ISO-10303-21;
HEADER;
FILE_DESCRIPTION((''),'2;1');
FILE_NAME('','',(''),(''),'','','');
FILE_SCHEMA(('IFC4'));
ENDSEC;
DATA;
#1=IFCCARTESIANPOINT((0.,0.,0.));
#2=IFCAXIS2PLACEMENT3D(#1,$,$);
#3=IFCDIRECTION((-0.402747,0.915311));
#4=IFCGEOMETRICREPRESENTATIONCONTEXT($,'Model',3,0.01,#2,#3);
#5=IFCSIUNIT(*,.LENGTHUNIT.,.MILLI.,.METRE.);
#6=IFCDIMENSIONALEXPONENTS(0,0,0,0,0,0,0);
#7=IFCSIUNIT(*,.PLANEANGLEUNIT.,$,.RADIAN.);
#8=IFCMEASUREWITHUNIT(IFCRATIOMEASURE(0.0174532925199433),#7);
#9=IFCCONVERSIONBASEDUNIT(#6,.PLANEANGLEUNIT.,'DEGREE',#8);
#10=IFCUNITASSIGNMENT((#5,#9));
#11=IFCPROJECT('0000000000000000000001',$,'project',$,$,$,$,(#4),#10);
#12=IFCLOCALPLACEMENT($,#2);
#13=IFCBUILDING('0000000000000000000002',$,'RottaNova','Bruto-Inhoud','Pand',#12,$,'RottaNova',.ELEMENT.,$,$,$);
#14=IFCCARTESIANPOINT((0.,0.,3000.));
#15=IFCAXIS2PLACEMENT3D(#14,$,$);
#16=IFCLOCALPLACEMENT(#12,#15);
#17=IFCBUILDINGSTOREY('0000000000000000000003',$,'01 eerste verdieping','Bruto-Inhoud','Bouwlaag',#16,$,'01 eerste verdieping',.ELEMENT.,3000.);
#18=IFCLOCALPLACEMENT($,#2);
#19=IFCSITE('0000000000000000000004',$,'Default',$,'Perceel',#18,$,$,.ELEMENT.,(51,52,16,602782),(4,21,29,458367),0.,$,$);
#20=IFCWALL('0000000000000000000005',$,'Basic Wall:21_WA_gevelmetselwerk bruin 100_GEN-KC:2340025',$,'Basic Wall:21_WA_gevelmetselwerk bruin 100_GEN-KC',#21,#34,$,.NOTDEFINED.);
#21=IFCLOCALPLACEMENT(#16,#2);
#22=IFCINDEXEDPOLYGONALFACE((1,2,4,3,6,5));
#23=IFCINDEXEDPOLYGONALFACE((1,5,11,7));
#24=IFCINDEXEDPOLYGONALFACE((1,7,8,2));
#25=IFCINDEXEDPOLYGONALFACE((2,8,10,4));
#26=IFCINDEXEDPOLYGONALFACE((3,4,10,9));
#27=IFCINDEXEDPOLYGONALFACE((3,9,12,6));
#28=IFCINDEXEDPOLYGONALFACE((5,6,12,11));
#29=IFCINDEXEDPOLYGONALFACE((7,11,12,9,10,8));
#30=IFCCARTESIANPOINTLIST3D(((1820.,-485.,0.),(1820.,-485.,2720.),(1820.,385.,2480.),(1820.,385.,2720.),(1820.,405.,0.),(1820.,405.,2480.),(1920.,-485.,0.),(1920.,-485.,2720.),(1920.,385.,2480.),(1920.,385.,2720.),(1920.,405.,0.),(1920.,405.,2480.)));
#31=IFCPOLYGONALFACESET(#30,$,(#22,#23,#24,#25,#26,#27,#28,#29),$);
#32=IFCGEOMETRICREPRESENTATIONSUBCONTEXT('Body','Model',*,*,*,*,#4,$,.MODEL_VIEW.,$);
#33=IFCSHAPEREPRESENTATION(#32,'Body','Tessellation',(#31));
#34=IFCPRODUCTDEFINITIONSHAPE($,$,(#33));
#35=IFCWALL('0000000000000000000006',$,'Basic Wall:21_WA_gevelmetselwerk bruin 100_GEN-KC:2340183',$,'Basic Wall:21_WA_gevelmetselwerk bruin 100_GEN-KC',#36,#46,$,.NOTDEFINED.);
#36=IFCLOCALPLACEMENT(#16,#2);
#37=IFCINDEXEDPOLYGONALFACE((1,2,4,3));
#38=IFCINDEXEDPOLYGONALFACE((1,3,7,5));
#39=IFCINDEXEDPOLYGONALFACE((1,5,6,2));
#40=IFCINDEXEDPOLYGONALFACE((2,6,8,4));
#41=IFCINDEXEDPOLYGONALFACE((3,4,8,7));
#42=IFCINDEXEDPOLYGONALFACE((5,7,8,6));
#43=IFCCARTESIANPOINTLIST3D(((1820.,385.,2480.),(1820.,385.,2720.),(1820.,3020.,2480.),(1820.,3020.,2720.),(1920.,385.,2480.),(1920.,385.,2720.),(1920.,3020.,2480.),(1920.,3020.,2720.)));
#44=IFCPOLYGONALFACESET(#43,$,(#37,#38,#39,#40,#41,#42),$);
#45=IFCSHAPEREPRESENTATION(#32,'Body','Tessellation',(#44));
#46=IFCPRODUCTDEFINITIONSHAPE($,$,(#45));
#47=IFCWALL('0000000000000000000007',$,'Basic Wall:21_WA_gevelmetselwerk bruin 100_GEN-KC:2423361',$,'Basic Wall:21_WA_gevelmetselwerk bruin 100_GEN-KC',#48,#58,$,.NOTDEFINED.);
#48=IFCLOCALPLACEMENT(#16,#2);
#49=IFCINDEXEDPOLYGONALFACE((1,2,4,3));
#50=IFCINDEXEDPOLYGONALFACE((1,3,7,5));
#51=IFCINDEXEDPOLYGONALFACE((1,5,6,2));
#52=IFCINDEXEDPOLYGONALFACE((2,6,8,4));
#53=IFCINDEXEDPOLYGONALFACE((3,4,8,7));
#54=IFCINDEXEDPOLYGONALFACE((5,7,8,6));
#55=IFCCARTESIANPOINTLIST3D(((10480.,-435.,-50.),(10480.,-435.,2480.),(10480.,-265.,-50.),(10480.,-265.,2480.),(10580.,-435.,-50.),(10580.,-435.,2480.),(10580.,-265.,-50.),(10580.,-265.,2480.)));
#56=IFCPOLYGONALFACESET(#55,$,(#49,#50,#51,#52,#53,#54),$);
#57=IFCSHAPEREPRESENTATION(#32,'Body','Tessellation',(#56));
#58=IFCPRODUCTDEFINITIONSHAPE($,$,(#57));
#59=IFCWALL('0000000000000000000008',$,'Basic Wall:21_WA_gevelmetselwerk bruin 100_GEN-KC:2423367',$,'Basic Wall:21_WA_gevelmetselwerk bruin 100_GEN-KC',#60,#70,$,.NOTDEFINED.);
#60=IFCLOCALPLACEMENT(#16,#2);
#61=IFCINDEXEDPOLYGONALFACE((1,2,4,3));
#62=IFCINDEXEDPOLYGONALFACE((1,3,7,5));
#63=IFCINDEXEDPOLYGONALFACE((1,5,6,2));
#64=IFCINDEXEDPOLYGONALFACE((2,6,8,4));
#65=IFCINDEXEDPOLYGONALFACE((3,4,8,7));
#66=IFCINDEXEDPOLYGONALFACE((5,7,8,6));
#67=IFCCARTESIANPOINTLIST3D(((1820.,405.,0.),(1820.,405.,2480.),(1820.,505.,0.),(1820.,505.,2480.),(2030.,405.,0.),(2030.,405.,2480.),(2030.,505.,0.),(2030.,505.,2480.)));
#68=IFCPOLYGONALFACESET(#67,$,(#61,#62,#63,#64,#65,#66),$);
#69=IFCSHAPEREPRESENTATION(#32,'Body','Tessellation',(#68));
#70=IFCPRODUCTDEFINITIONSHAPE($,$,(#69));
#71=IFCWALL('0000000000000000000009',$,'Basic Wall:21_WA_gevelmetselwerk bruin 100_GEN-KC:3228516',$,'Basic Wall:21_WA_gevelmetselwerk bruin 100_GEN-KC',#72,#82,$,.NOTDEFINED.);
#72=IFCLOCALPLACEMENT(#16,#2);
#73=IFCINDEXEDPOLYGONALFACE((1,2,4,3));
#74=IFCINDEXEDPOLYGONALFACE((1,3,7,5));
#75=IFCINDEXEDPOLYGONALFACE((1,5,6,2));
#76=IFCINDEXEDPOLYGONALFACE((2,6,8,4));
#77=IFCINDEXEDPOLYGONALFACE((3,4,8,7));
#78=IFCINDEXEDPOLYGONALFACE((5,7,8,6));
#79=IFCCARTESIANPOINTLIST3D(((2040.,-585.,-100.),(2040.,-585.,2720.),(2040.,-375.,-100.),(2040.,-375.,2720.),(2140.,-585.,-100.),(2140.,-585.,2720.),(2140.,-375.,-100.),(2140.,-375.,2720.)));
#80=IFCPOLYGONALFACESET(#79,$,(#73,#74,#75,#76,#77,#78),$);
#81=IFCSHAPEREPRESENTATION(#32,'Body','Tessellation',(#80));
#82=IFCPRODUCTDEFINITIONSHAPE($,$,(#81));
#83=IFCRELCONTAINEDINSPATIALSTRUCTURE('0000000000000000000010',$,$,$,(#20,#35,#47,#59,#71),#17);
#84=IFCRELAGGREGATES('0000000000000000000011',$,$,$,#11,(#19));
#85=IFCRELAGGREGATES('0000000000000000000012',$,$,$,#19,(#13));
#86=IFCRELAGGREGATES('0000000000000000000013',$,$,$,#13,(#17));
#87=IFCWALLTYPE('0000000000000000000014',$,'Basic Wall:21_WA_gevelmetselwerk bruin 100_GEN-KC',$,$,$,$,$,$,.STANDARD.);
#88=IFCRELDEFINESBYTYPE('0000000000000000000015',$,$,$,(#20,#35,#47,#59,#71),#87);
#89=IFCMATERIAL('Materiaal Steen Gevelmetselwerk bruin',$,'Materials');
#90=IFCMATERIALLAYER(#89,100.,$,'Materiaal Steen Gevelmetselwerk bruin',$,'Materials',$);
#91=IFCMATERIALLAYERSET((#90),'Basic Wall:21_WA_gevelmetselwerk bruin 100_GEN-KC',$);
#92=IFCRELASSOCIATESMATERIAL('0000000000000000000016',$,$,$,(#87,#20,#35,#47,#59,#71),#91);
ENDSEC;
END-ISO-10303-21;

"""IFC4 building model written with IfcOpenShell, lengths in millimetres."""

from ifc_helpers import new_model, entity, si_unit, converted_unit, direction, frame, frame_2d, origin, place, context, subcontext, project, spatial, polyline, rectangle, extrude, clip, bounded_halfspace, material, layer, layer_set, type_object, element, save


model = new_model("IFC4")

# Units and contexts
model_context = context("Model", 3, precision=0.01, world=origin(), true_north=direction((-0.402747, 0.915311)))
body_context = subcontext(model_context, "Body", "Model", "MODEL_VIEW")
ifc_project = project(units=[si_unit("LENGTHUNIT", "METRE", prefix="MILLI"), converted_unit("PLANEANGLEUNIT", "DEGREE", entity("IfcRatioMeasure", 0.0174532925199433), si_unit("PLANEANGLEUNIT", "RADIAN"), dimensions=[0, 0, 0, 0, 0, 0, 0])], contexts=[model_context])

# Site, building, storey
site_placement = place(None, origin())
site = spatial("IfcSite", under=ifc_project, at=site_placement, Name="Default", ObjectType="Perceel", CompositionType="ELEMENT", RefLatitude=(51, 52, 16, 602782), RefLongitude=(4, 21, 29, 458367), RefElevation=0.0)
building_placement = place(None, origin())
building = spatial("IfcBuilding", under=site, at=building_placement, Name="RottaNova", Description="Bruto-Inhoud", ObjectType="Pand", LongName="RottaNova", CompositionType="ELEMENT")
storey_placement = place(building_placement, frame((0.0, 0.0, 3000.0)))
storey = spatial("IfcBuildingStorey", under=building, at=storey_placement, Name="01 eerste verdieping", Description="Bruto-Inhoud", ObjectType="Bouwlaag", LongName="01 eerste verdieping", CompositionType="ELEMENT", Elevation=3000.0)

# Walls
ifc_material_1 = material(Name="Materiaal Steen Gevelmetselwerk bruin", Category="Materials")
ifc_layer_1 = layer(ifc_material_1, 100.0, Name="Materiaal Steen Gevelmetselwerk bruin", Category="Materials")
ifc_layer_set_1 = layer_set([ifc_layer_1], Name="Basic Wall:21_WA_gevelmetselwerk bruin 100_GEN-KC")
wall_type_1 = type_object("IfcWallType", Name="Basic Wall:21_WA_gevelmetselwerk bruin 100_GEN-KC", PredefinedType="STANDARD", material=ifc_layer_set_1)
wall_1_placement = place(storey_placement, frame((1870.0, 405.0, 0.0), z_axis=(0.0, 0.0, 1.0), x_axis=(0.0, -1.0, 0.0)))
element("IfcWall", 1, at=wall_1_placement, inside=storey, type_object=wall_type_1, material=ifc_layer_set_1, Name="Basic Wall:21_WA_gevelmetselwerk bruin 100_GEN-KC:2340025", ObjectType="Basic Wall:21_WA_gevelmetselwerk bruin 100_GEN-KC", PredefinedType="NOTDEFINED", context=body_context, shape_type="Clipping", body=[
    clip(clip(extrude(rectangle(XDim=890.0, YDim=100.0, at=frame_2d((445.0, 0.0), x_axis=(-1.0, 0.0))), origin(), (0.0, 0.0, 1.0), 2720.0), bounded_halfspace(frame((20.0, -50.0, 2480.0), z_axis=(0.0, 0.0, -1.0), x_axis=(0.0, 1.0, 0.0)), True, frame((20.0, -50.0, 2480.0), z_axis=(0.0, 0.0, -1.0), x_axis=(0.0, 1.0, 0.0)), polyline([(0.0, 0.0), (0.0, -20.0), (100.0, -20.0), (100.0, 0.0), (0.0, 0.0)]))), bounded_halfspace(frame((20.0, 50.0, 2480.0), z_axis=(1.0, 0.0, 0.0), x_axis=(0.0, 1.0, 0.0)), True, frame((20.0, 50.0, 2480.0), z_axis=(1.0, 0.0, 0.0), x_axis=(0.0, 1.0, 0.0)), polyline([(0.0, 0.0), (0.0, 73152.0), (-30480.0, 73152.0), (-30480.0, 0.0), (0.0, 0.0)]))),
])
wall_2_placement = place(storey_placement, frame((1870.0, 3020.0, 2480.0), z_axis=(0.0, 0.0, 1.0), x_axis=(0.0, -1.0, 0.0)))
element("IfcWall", 2, at=wall_2_placement, inside=storey, type_object=wall_type_1, material=ifc_layer_set_1, Name="Basic Wall:21_WA_gevelmetselwerk bruin 100_GEN-KC:2340183", ObjectType="Basic Wall:21_WA_gevelmetselwerk bruin 100_GEN-KC", PredefinedType="NOTDEFINED", context=body_context, shape_type="SweptSolid", body=[
    extrude(rectangle(XDim=2635.0, YDim=100.0, at=frame_2d((1317.5, 0.0), x_axis=(-1.0, 0.0))), origin(), (0.0, 0.0, 1.0), 240.0),
])
wall_3_placement = place(storey_placement, frame((10530.0, -265.0, -50.0), z_axis=(0.0, 0.0, 1.0), x_axis=(0.0, -1.0, 0.0)))
element("IfcWall", 3, at=wall_3_placement, inside=storey, type_object=wall_type_1, material=ifc_layer_set_1, Name="Basic Wall:21_WA_gevelmetselwerk bruin 100_GEN-KC:2423361", ObjectType="Basic Wall:21_WA_gevelmetselwerk bruin 100_GEN-KC", PredefinedType="NOTDEFINED", context=body_context, shape_type="SweptSolid", body=[
    extrude(rectangle(XDim=170.0, YDim=100.0, at=frame_2d((85.0, 0.0), x_axis=(-1.0, 0.0))), origin(), (0.0, 0.0, 1.0), 2530.0),
])
wall_4_placement = place(storey_placement, frame((2030.0, 455.0, 0.0), z_axis=(0.0, 0.0, 1.0), x_axis=(-1.0, 0.0, 0.0)))
element("IfcWall", 4, at=wall_4_placement, inside=storey, type_object=wall_type_1, material=ifc_layer_set_1, Name="Basic Wall:21_WA_gevelmetselwerk bruin 100_GEN-KC:2423367", ObjectType="Basic Wall:21_WA_gevelmetselwerk bruin 100_GEN-KC", PredefinedType="NOTDEFINED", context=body_context, shape_type="SweptSolid", body=[
    extrude(rectangle(XDim=210.0, YDim=100.0, at=frame_2d((105.0, 0.0), x_axis=(-1.0, 0.0))), origin(), (0.0, 0.0, 1.0), 2480.0),
])
wall_5_placement = place(storey_placement, frame((2090.0, -585.0, -100.0), z_axis=(0.0, 0.0, 1.0), x_axis=(0.0, 1.0, 0.0)))
element("IfcWall", 5, at=wall_5_placement, inside=storey, type_object=wall_type_1, material=ifc_layer_set_1, Name="Basic Wall:21_WA_gevelmetselwerk bruin 100_GEN-KC:3228516", ObjectType="Basic Wall:21_WA_gevelmetselwerk bruin 100_GEN-KC", PredefinedType="NOTDEFINED", context=body_context, shape_type="SweptSolid", body=[
    extrude(rectangle(XDim=210.0, YDim=100.0, at=frame_2d((105.0, 0.0), x_axis=(-1.0, 0.0))), origin(), (0.0, 0.0, 1.0), 2820.0),
])

save(model, "model.ifc")
